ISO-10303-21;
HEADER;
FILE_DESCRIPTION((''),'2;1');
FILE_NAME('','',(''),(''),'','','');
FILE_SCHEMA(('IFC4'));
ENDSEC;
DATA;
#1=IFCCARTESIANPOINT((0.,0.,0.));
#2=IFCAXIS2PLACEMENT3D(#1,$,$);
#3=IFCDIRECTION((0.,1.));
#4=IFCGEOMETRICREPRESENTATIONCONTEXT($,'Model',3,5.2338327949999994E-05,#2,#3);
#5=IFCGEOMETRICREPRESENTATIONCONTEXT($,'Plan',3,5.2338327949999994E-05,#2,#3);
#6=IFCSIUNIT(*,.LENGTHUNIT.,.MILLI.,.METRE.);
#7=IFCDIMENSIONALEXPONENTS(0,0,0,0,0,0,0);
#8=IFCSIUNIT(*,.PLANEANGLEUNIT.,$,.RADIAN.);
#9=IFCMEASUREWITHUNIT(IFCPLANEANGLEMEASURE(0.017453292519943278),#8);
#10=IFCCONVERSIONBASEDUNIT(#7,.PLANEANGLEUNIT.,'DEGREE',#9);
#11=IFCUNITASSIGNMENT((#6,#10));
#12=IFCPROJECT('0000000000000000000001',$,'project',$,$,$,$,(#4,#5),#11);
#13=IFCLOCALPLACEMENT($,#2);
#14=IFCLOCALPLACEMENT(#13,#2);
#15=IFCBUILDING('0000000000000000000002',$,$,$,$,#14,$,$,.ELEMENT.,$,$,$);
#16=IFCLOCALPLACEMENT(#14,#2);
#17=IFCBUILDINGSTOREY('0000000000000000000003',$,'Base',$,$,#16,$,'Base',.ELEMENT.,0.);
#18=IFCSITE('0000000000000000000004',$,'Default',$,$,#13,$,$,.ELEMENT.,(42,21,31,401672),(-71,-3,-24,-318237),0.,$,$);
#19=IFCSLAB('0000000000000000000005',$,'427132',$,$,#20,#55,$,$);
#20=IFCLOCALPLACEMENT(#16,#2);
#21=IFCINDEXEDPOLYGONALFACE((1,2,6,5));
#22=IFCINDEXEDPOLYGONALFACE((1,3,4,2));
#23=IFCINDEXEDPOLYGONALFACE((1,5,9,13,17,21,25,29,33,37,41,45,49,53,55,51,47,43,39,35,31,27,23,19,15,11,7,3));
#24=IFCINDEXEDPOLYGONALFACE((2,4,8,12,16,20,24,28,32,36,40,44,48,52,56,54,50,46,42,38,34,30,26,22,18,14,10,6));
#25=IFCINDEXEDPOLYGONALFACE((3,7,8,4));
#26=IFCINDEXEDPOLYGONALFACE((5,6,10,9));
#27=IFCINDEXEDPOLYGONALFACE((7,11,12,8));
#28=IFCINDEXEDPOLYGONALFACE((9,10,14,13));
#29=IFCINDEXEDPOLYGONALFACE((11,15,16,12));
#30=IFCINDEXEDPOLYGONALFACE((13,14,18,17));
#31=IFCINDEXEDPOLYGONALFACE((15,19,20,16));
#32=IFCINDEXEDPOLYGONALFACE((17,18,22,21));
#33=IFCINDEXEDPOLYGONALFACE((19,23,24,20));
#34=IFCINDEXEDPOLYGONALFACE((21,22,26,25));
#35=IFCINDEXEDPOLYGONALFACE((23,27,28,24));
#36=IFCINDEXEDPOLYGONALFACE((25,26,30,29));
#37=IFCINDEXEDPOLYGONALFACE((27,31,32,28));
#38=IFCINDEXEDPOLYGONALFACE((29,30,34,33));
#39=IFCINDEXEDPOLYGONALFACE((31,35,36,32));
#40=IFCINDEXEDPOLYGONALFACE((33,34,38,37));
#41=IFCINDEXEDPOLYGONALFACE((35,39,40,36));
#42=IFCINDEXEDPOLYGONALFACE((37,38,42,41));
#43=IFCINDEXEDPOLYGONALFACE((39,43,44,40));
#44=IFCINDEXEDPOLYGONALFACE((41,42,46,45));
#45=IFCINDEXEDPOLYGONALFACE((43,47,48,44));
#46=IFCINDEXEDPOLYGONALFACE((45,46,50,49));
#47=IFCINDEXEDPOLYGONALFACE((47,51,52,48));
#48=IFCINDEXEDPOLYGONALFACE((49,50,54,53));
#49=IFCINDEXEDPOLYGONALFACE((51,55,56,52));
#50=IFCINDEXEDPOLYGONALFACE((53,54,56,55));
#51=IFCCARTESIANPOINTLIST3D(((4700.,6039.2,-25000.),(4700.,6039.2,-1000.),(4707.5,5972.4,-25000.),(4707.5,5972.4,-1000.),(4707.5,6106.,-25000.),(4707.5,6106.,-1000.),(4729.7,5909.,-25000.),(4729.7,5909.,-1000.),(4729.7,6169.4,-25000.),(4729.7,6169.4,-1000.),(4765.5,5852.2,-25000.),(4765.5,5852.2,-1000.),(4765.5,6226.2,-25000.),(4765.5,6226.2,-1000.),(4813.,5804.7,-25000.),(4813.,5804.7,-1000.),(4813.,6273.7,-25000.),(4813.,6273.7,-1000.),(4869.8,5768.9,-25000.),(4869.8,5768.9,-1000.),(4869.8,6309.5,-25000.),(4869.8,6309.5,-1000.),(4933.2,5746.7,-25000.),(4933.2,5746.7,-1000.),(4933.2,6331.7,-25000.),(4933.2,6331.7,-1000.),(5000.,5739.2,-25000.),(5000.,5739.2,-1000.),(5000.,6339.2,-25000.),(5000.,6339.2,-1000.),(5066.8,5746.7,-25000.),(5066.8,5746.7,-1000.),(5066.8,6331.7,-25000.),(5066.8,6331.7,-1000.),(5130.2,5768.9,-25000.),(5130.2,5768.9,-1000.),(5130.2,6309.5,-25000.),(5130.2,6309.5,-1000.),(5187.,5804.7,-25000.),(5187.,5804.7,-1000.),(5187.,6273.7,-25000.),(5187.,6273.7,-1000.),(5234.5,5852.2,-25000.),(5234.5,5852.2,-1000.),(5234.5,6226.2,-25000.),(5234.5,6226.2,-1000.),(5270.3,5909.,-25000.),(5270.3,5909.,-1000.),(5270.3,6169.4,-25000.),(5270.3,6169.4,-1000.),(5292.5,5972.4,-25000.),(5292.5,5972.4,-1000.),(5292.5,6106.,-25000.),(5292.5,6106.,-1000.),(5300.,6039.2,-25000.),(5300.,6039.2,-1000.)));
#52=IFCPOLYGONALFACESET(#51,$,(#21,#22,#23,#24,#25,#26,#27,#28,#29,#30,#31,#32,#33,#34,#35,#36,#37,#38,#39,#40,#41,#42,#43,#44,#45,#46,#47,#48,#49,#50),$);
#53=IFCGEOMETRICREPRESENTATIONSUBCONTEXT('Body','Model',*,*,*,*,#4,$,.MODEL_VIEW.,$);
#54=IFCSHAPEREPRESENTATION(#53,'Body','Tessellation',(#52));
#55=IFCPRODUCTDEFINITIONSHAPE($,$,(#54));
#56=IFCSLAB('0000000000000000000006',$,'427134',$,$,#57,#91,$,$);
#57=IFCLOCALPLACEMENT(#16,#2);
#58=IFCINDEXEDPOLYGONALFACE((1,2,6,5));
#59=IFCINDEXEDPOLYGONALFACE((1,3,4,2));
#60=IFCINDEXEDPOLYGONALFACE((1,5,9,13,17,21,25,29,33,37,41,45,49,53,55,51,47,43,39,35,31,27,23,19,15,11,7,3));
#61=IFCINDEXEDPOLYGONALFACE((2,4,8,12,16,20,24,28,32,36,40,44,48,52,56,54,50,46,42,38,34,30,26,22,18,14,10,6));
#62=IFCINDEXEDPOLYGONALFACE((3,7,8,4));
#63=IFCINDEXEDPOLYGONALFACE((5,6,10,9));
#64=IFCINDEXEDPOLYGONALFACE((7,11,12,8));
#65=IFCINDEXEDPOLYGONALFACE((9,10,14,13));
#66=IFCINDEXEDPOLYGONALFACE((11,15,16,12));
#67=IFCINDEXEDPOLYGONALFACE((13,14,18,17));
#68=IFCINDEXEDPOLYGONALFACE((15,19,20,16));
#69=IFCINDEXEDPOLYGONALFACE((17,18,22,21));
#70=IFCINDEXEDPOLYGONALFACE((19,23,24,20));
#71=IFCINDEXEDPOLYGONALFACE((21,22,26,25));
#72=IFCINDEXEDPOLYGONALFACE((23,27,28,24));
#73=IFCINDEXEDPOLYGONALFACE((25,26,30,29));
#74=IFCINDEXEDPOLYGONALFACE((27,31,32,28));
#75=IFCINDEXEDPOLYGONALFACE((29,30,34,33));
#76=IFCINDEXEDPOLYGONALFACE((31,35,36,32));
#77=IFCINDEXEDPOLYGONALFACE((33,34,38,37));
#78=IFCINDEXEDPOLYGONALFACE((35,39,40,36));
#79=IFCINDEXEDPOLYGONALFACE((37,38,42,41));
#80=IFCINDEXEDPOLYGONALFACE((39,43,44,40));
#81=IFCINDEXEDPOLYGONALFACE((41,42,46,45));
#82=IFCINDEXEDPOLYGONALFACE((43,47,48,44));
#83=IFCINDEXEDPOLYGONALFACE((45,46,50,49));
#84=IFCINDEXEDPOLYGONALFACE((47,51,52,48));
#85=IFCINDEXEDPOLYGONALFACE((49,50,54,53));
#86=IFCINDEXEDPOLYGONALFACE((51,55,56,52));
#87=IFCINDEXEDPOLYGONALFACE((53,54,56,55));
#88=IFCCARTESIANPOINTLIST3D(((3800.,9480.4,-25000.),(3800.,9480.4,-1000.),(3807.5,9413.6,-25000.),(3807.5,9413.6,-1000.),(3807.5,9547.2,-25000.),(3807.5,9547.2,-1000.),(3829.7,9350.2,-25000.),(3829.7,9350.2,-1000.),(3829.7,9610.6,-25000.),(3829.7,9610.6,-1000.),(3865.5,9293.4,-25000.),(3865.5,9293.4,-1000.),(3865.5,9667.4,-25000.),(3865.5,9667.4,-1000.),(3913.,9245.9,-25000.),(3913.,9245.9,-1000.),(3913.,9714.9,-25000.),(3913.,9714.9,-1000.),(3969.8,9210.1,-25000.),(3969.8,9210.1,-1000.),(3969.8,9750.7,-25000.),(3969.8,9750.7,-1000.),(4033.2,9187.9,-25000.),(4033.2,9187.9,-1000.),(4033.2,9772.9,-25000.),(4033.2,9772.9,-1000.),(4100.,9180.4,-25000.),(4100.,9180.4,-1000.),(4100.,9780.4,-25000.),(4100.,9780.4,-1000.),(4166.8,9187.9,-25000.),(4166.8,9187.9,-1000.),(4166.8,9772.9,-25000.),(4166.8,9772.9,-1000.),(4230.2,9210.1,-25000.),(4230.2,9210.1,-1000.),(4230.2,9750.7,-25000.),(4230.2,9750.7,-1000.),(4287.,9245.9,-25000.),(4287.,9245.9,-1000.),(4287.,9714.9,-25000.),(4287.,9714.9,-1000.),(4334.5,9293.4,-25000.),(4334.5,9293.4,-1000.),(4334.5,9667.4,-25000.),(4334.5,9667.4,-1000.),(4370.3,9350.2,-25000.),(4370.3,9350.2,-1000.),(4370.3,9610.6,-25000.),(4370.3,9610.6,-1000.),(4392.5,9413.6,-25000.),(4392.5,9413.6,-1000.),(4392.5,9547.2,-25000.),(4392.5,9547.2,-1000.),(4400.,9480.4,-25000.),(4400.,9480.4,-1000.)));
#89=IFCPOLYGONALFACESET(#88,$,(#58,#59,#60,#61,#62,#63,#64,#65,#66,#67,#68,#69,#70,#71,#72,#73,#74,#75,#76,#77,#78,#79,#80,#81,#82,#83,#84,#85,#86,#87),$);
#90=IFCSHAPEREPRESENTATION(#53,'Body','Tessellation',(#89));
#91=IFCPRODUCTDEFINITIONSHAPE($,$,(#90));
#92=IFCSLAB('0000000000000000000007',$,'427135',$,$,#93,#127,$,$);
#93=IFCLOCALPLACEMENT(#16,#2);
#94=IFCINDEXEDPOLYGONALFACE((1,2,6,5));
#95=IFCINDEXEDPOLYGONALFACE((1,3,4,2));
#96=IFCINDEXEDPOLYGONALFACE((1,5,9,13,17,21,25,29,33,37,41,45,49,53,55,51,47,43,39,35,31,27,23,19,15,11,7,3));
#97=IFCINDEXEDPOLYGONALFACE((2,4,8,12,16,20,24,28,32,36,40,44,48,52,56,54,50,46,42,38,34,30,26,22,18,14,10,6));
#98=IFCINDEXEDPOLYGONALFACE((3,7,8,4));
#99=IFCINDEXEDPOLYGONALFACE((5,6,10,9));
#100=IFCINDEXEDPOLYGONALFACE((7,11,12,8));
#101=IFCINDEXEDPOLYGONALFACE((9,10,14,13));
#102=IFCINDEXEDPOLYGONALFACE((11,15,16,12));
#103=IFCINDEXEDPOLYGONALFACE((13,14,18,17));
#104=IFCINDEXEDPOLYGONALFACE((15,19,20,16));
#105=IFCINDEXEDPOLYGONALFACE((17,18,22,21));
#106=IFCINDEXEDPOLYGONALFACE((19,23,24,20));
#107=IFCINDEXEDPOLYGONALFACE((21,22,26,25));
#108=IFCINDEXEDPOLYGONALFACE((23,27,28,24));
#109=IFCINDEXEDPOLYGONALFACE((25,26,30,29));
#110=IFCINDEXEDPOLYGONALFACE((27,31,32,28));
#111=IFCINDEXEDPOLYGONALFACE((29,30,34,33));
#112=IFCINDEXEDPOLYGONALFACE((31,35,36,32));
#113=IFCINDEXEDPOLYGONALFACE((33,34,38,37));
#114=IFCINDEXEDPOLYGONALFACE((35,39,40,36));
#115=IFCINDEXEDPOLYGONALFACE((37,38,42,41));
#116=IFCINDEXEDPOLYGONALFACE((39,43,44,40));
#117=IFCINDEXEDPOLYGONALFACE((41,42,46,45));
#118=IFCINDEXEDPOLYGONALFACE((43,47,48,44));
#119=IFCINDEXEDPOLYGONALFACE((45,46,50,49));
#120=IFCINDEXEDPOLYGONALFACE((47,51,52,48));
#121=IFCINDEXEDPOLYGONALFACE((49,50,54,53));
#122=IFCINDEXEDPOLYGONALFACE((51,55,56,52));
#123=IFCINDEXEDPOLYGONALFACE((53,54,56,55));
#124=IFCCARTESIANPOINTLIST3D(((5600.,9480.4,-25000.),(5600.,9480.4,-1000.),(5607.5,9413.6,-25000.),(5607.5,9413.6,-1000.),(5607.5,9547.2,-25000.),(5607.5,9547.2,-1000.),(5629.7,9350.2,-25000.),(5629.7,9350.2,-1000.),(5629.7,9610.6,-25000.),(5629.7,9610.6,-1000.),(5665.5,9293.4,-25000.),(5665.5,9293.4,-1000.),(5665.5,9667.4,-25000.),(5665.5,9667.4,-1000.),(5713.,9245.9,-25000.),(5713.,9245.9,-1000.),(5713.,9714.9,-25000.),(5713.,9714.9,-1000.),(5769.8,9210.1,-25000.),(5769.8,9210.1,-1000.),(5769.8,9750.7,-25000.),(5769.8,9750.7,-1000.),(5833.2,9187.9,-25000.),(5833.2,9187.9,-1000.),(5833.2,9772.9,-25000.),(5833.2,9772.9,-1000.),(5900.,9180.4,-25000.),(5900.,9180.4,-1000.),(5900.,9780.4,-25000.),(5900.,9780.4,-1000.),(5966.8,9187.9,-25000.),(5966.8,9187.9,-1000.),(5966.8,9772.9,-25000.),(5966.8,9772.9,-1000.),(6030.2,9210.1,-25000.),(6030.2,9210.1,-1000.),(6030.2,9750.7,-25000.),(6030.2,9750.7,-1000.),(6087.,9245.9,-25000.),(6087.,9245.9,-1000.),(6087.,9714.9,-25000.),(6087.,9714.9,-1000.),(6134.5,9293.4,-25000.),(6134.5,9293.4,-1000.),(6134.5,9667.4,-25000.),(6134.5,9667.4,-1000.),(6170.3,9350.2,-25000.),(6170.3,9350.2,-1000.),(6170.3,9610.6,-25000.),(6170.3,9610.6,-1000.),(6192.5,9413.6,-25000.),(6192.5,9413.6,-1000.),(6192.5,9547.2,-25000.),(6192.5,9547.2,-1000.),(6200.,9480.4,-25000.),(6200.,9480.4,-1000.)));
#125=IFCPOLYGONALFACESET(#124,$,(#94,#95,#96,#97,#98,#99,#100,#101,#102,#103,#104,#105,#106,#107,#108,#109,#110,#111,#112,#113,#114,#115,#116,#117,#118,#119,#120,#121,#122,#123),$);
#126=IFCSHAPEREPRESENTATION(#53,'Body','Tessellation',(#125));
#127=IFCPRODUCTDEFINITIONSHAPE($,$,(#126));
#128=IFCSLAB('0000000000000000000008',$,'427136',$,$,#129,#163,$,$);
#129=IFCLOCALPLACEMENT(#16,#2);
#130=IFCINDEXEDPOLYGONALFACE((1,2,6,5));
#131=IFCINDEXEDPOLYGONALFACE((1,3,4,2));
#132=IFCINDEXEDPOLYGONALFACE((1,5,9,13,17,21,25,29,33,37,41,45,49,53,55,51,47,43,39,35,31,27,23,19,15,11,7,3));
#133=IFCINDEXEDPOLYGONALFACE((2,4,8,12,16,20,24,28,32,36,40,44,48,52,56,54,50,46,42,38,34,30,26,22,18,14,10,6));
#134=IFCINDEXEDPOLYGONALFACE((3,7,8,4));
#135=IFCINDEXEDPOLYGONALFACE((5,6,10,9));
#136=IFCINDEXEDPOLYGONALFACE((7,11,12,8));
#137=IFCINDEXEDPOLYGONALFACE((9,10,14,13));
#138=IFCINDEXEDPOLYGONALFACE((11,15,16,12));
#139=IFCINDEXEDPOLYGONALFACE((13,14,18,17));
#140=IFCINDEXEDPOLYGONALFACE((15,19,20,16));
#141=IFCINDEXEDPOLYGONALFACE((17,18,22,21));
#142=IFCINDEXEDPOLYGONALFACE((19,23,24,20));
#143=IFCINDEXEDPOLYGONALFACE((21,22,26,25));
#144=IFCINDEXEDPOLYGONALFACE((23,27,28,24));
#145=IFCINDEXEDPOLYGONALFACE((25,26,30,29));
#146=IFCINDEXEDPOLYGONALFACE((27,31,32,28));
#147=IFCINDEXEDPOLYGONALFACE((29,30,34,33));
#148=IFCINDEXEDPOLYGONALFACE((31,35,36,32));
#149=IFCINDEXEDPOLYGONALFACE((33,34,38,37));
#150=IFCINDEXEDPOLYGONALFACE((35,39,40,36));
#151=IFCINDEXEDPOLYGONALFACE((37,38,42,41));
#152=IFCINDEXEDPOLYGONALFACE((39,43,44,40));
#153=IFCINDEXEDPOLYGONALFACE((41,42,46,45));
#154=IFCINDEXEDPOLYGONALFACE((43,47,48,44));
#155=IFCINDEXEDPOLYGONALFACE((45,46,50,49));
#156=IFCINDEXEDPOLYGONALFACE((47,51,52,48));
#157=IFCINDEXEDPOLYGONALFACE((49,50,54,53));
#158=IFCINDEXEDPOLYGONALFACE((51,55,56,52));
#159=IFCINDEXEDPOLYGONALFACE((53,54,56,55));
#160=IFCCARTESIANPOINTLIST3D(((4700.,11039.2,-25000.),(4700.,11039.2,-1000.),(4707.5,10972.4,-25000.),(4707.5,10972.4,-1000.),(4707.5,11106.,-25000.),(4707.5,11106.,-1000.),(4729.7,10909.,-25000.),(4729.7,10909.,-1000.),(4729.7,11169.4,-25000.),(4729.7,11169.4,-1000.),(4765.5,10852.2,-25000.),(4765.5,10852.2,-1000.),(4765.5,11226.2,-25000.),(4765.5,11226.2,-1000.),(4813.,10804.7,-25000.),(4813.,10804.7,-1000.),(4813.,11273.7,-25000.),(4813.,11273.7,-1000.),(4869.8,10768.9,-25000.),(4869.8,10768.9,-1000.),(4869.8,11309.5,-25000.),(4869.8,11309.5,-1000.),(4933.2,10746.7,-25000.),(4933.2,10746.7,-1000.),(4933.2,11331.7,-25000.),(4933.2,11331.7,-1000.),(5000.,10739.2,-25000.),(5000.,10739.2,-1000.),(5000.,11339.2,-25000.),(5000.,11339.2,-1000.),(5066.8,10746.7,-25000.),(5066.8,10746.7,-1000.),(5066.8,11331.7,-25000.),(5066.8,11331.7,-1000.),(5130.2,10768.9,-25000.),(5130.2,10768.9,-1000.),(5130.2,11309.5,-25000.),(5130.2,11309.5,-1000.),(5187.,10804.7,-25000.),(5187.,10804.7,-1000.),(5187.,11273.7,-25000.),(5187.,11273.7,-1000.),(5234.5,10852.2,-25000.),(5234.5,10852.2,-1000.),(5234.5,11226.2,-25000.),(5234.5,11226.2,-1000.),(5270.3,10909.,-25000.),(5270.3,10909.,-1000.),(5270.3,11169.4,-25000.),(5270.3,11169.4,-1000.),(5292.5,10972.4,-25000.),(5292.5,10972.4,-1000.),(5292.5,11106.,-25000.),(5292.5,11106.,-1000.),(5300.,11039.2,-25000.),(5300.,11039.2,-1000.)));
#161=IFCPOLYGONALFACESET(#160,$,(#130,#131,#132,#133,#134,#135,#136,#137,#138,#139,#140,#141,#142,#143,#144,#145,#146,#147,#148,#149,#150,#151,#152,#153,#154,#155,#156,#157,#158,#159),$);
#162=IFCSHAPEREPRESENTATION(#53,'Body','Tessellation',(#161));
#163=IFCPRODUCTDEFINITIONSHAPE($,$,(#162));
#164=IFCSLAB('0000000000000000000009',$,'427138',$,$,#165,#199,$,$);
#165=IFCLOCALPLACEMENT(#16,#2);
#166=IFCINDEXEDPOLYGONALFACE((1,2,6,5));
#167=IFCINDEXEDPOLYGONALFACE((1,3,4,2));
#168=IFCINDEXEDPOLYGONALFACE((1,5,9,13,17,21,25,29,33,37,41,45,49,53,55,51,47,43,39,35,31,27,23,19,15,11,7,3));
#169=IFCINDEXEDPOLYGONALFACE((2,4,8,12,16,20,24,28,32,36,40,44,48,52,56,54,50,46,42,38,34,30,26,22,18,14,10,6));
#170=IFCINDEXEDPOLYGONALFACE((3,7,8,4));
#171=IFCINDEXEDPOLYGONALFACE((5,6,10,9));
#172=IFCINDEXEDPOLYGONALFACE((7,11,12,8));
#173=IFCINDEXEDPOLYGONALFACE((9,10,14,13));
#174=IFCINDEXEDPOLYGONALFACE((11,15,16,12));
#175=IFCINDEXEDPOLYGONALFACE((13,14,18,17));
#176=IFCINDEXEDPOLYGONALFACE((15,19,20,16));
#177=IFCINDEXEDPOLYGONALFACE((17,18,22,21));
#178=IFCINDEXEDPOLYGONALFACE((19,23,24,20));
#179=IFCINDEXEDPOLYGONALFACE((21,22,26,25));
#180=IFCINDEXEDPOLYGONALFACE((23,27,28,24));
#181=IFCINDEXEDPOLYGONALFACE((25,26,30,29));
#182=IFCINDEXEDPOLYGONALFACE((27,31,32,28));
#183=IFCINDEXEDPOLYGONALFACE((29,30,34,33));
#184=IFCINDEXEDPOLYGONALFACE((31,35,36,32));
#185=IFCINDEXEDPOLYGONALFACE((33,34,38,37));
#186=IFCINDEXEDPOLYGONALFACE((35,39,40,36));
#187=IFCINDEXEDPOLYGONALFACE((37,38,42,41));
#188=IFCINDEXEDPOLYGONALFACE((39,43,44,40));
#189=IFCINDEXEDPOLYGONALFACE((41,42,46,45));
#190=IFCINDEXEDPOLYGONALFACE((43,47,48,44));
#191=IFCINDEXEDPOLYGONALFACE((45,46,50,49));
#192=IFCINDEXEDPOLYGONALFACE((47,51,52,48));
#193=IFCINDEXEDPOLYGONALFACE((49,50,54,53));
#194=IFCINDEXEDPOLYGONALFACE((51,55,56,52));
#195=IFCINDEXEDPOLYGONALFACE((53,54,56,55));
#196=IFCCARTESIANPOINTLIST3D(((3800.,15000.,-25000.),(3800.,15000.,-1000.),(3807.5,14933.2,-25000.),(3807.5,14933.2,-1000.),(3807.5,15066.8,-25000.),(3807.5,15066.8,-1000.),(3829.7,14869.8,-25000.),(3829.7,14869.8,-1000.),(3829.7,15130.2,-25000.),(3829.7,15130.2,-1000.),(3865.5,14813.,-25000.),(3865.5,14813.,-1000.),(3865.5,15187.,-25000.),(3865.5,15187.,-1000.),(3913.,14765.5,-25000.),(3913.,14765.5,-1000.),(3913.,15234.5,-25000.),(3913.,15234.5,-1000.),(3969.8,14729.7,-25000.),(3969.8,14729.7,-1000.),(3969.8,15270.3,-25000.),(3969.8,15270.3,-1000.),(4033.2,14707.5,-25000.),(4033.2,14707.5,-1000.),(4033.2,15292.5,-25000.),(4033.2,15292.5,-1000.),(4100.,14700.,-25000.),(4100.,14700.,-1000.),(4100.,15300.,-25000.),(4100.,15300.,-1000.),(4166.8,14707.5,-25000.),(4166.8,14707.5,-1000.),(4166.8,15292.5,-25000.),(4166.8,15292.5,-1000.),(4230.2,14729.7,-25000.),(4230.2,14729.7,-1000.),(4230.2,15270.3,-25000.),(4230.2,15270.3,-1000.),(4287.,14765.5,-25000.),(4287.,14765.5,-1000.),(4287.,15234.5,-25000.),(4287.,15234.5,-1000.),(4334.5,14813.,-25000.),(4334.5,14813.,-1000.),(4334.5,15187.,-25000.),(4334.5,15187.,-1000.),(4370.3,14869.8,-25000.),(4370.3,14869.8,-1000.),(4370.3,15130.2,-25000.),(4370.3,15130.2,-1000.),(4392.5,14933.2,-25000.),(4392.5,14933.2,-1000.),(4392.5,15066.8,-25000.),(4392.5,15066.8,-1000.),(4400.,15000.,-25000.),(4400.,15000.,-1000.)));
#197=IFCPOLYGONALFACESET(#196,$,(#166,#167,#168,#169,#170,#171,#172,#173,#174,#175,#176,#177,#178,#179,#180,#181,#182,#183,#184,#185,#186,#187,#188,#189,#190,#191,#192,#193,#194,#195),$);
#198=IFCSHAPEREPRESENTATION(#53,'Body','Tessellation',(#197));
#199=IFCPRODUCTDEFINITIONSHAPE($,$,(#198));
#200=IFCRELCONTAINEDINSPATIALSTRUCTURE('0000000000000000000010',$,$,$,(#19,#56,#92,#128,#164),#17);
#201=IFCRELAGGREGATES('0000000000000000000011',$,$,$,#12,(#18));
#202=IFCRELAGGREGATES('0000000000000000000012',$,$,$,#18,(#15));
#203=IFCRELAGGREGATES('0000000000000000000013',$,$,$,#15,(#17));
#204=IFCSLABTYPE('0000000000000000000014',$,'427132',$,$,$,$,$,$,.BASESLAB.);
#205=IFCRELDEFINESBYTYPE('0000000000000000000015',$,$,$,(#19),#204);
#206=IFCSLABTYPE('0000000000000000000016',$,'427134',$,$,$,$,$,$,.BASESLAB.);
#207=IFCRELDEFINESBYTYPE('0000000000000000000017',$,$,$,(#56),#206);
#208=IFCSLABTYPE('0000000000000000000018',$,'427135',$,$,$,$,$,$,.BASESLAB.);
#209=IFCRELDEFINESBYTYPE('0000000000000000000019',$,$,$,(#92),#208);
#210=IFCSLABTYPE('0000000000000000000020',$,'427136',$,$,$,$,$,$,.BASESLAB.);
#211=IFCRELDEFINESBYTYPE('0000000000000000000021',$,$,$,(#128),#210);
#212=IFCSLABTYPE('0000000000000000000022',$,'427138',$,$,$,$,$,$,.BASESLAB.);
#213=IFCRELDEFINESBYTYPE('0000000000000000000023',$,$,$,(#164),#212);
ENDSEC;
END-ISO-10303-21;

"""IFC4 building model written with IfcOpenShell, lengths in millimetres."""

from ifc_helpers import new_model, entity, si_unit, converted_unit, direction, frame, origin, place, context, subcontext, project, spatial, arc, indexed_curve, outline, extrude, type_object, element, save


model = new_model("IFC4")

# Units and contexts
model_context = context("Model", 3, precision=5.2338327949999994e-05, world=origin(), true_north=direction((0.0, 1.0)))
plan_context = context("Plan", 3, precision=5.2338327949999994e-05, world=origin(), true_north=direction((0.0, 1.0)))
body_context = subcontext(model_context, "Body", "Model", "MODEL_VIEW")
ifc_project = project(units=[si_unit("LENGTHUNIT", "METRE", prefix="MILLI"), converted_unit("PLANEANGLEUNIT", "DEGREE", entity("IfcPlaneAngleMeasure", 0.017453292519943278), si_unit("PLANEANGLEUNIT", "RADIAN"), dimensions=[0, 0, 0, 0, 0, 0, 0])], contexts=[model_context, plan_context])

# Site, building, storey
site_placement = place(None, origin())
site = spatial("IfcSite", under=ifc_project, at=site_placement, Name="Default", CompositionType="ELEMENT", RefLatitude=(42, 21, 31, 401672), RefLongitude=(-71, -3, -24, -318237), RefElevation=0.0)
building_placement = place(site_placement, origin())
building = spatial("IfcBuilding", under=site, at=building_placement, CompositionType="ELEMENT")
storey_placement = place(building_placement, origin())
storey = spatial("IfcBuildingStorey", under=building, at=storey_placement, Name="Base", LongName="Base", CompositionType="ELEMENT", Elevation=0.0)

# Slabs
slab_type_1 = type_object("IfcSlabType", Name="427132", PredefinedType="BASESLAB")
slab_1_placement = place(storey_placement, origin())
element("IfcSlab", 1, at=slab_1_placement, inside=storey, type_object=slab_type_1, Name="427132", context=body_context, shape_type="SweptSolid", body=[
    extrude(outline(indexed_curve([(300.0, 0.0), (0.0, 300.0), (-300.0, 0.0), (0.0, -300.0)], segments=[arc(1, 2, 3), arc(3, 4, 1)], self_intersect=False)), frame((5000.0, 6039.2, -25000.0)), (0.0, 0.0, 1.0), 24000.0),
])
slab_type_2 = type_object("IfcSlabType", Name="427134", PredefinedType="BASESLAB")
slab_2_placement = place(storey_placement, origin())
element("IfcSlab", 2, at=slab_2_placement, inside=storey, type_object=slab_type_2, Name="427134", context=body_context, shape_type="SweptSolid", body=[
    extrude(outline(indexed_curve([(300.0, 0.0), (0.0, 300.0), (-300.0, 0.0), (0.0, -300.0)], segments=[arc(1, 2, 3), arc(3, 4, 1)], self_intersect=False)), frame((4100.0, 9480.4, -25000.0)), (0.0, 0.0, 1.0), 24000.0),
])
slab_type_3 = type_object("IfcSlabType", Name="427135", PredefinedType="BASESLAB")
slab_3_placement = place(storey_placement, origin())
element("IfcSlab", 3, at=slab_3_placement, inside=storey, type_object=slab_type_3, Name="427135", context=body_context, shape_type="SweptSolid", body=[
    extrude(outline(indexed_curve([(300.0, 0.0), (0.0, 300.0), (-300.0, 0.0), (0.0, -300.0)], segments=[arc(1, 2, 3), arc(3, 4, 1)], self_intersect=False)), frame((5900.0, 9480.4, -25000.0)), (0.0, 0.0, 1.0), 24000.0),
])
slab_type_4 = type_object("IfcSlabType", Name="427136", PredefinedType="BASESLAB")
slab_4_placement = place(storey_placement, origin())
element("IfcSlab", 4, at=slab_4_placement, inside=storey, type_object=slab_type_4, Name="427136", context=body_context, shape_type="SweptSolid", body=[
    extrude(outline(indexed_curve([(300.0, 0.0), (0.0, 300.0), (-300.0, 0.0), (0.0, -300.0)], segments=[arc(1, 2, 3), arc(3, 4, 1)], self_intersect=False)), frame((5000.0, 11039.2, -25000.0)), (0.0, 0.0, 1.0), 24000.0),
])
slab_type_5 = type_object("IfcSlabType", Name="427138", PredefinedType="BASESLAB")
slab_5_placement = place(storey_placement, origin())
element("IfcSlab", 5, at=slab_5_placement, inside=storey, type_object=slab_type_5, Name="427138", context=body_context, shape_type="SweptSolid", body=[
    extrude(outline(indexed_curve([(300.0, 0.0), (0.0, 300.0), (-300.0, 0.0), (0.0, -300.0)], segments=[arc(1, 2, 3), arc(3, 4, 1)], self_intersect=False)), frame((4100.0, 15000.0, -25000.0)), (0.0, 0.0, 1.0), 24000.0),
])

save(model, "model.ifc")
